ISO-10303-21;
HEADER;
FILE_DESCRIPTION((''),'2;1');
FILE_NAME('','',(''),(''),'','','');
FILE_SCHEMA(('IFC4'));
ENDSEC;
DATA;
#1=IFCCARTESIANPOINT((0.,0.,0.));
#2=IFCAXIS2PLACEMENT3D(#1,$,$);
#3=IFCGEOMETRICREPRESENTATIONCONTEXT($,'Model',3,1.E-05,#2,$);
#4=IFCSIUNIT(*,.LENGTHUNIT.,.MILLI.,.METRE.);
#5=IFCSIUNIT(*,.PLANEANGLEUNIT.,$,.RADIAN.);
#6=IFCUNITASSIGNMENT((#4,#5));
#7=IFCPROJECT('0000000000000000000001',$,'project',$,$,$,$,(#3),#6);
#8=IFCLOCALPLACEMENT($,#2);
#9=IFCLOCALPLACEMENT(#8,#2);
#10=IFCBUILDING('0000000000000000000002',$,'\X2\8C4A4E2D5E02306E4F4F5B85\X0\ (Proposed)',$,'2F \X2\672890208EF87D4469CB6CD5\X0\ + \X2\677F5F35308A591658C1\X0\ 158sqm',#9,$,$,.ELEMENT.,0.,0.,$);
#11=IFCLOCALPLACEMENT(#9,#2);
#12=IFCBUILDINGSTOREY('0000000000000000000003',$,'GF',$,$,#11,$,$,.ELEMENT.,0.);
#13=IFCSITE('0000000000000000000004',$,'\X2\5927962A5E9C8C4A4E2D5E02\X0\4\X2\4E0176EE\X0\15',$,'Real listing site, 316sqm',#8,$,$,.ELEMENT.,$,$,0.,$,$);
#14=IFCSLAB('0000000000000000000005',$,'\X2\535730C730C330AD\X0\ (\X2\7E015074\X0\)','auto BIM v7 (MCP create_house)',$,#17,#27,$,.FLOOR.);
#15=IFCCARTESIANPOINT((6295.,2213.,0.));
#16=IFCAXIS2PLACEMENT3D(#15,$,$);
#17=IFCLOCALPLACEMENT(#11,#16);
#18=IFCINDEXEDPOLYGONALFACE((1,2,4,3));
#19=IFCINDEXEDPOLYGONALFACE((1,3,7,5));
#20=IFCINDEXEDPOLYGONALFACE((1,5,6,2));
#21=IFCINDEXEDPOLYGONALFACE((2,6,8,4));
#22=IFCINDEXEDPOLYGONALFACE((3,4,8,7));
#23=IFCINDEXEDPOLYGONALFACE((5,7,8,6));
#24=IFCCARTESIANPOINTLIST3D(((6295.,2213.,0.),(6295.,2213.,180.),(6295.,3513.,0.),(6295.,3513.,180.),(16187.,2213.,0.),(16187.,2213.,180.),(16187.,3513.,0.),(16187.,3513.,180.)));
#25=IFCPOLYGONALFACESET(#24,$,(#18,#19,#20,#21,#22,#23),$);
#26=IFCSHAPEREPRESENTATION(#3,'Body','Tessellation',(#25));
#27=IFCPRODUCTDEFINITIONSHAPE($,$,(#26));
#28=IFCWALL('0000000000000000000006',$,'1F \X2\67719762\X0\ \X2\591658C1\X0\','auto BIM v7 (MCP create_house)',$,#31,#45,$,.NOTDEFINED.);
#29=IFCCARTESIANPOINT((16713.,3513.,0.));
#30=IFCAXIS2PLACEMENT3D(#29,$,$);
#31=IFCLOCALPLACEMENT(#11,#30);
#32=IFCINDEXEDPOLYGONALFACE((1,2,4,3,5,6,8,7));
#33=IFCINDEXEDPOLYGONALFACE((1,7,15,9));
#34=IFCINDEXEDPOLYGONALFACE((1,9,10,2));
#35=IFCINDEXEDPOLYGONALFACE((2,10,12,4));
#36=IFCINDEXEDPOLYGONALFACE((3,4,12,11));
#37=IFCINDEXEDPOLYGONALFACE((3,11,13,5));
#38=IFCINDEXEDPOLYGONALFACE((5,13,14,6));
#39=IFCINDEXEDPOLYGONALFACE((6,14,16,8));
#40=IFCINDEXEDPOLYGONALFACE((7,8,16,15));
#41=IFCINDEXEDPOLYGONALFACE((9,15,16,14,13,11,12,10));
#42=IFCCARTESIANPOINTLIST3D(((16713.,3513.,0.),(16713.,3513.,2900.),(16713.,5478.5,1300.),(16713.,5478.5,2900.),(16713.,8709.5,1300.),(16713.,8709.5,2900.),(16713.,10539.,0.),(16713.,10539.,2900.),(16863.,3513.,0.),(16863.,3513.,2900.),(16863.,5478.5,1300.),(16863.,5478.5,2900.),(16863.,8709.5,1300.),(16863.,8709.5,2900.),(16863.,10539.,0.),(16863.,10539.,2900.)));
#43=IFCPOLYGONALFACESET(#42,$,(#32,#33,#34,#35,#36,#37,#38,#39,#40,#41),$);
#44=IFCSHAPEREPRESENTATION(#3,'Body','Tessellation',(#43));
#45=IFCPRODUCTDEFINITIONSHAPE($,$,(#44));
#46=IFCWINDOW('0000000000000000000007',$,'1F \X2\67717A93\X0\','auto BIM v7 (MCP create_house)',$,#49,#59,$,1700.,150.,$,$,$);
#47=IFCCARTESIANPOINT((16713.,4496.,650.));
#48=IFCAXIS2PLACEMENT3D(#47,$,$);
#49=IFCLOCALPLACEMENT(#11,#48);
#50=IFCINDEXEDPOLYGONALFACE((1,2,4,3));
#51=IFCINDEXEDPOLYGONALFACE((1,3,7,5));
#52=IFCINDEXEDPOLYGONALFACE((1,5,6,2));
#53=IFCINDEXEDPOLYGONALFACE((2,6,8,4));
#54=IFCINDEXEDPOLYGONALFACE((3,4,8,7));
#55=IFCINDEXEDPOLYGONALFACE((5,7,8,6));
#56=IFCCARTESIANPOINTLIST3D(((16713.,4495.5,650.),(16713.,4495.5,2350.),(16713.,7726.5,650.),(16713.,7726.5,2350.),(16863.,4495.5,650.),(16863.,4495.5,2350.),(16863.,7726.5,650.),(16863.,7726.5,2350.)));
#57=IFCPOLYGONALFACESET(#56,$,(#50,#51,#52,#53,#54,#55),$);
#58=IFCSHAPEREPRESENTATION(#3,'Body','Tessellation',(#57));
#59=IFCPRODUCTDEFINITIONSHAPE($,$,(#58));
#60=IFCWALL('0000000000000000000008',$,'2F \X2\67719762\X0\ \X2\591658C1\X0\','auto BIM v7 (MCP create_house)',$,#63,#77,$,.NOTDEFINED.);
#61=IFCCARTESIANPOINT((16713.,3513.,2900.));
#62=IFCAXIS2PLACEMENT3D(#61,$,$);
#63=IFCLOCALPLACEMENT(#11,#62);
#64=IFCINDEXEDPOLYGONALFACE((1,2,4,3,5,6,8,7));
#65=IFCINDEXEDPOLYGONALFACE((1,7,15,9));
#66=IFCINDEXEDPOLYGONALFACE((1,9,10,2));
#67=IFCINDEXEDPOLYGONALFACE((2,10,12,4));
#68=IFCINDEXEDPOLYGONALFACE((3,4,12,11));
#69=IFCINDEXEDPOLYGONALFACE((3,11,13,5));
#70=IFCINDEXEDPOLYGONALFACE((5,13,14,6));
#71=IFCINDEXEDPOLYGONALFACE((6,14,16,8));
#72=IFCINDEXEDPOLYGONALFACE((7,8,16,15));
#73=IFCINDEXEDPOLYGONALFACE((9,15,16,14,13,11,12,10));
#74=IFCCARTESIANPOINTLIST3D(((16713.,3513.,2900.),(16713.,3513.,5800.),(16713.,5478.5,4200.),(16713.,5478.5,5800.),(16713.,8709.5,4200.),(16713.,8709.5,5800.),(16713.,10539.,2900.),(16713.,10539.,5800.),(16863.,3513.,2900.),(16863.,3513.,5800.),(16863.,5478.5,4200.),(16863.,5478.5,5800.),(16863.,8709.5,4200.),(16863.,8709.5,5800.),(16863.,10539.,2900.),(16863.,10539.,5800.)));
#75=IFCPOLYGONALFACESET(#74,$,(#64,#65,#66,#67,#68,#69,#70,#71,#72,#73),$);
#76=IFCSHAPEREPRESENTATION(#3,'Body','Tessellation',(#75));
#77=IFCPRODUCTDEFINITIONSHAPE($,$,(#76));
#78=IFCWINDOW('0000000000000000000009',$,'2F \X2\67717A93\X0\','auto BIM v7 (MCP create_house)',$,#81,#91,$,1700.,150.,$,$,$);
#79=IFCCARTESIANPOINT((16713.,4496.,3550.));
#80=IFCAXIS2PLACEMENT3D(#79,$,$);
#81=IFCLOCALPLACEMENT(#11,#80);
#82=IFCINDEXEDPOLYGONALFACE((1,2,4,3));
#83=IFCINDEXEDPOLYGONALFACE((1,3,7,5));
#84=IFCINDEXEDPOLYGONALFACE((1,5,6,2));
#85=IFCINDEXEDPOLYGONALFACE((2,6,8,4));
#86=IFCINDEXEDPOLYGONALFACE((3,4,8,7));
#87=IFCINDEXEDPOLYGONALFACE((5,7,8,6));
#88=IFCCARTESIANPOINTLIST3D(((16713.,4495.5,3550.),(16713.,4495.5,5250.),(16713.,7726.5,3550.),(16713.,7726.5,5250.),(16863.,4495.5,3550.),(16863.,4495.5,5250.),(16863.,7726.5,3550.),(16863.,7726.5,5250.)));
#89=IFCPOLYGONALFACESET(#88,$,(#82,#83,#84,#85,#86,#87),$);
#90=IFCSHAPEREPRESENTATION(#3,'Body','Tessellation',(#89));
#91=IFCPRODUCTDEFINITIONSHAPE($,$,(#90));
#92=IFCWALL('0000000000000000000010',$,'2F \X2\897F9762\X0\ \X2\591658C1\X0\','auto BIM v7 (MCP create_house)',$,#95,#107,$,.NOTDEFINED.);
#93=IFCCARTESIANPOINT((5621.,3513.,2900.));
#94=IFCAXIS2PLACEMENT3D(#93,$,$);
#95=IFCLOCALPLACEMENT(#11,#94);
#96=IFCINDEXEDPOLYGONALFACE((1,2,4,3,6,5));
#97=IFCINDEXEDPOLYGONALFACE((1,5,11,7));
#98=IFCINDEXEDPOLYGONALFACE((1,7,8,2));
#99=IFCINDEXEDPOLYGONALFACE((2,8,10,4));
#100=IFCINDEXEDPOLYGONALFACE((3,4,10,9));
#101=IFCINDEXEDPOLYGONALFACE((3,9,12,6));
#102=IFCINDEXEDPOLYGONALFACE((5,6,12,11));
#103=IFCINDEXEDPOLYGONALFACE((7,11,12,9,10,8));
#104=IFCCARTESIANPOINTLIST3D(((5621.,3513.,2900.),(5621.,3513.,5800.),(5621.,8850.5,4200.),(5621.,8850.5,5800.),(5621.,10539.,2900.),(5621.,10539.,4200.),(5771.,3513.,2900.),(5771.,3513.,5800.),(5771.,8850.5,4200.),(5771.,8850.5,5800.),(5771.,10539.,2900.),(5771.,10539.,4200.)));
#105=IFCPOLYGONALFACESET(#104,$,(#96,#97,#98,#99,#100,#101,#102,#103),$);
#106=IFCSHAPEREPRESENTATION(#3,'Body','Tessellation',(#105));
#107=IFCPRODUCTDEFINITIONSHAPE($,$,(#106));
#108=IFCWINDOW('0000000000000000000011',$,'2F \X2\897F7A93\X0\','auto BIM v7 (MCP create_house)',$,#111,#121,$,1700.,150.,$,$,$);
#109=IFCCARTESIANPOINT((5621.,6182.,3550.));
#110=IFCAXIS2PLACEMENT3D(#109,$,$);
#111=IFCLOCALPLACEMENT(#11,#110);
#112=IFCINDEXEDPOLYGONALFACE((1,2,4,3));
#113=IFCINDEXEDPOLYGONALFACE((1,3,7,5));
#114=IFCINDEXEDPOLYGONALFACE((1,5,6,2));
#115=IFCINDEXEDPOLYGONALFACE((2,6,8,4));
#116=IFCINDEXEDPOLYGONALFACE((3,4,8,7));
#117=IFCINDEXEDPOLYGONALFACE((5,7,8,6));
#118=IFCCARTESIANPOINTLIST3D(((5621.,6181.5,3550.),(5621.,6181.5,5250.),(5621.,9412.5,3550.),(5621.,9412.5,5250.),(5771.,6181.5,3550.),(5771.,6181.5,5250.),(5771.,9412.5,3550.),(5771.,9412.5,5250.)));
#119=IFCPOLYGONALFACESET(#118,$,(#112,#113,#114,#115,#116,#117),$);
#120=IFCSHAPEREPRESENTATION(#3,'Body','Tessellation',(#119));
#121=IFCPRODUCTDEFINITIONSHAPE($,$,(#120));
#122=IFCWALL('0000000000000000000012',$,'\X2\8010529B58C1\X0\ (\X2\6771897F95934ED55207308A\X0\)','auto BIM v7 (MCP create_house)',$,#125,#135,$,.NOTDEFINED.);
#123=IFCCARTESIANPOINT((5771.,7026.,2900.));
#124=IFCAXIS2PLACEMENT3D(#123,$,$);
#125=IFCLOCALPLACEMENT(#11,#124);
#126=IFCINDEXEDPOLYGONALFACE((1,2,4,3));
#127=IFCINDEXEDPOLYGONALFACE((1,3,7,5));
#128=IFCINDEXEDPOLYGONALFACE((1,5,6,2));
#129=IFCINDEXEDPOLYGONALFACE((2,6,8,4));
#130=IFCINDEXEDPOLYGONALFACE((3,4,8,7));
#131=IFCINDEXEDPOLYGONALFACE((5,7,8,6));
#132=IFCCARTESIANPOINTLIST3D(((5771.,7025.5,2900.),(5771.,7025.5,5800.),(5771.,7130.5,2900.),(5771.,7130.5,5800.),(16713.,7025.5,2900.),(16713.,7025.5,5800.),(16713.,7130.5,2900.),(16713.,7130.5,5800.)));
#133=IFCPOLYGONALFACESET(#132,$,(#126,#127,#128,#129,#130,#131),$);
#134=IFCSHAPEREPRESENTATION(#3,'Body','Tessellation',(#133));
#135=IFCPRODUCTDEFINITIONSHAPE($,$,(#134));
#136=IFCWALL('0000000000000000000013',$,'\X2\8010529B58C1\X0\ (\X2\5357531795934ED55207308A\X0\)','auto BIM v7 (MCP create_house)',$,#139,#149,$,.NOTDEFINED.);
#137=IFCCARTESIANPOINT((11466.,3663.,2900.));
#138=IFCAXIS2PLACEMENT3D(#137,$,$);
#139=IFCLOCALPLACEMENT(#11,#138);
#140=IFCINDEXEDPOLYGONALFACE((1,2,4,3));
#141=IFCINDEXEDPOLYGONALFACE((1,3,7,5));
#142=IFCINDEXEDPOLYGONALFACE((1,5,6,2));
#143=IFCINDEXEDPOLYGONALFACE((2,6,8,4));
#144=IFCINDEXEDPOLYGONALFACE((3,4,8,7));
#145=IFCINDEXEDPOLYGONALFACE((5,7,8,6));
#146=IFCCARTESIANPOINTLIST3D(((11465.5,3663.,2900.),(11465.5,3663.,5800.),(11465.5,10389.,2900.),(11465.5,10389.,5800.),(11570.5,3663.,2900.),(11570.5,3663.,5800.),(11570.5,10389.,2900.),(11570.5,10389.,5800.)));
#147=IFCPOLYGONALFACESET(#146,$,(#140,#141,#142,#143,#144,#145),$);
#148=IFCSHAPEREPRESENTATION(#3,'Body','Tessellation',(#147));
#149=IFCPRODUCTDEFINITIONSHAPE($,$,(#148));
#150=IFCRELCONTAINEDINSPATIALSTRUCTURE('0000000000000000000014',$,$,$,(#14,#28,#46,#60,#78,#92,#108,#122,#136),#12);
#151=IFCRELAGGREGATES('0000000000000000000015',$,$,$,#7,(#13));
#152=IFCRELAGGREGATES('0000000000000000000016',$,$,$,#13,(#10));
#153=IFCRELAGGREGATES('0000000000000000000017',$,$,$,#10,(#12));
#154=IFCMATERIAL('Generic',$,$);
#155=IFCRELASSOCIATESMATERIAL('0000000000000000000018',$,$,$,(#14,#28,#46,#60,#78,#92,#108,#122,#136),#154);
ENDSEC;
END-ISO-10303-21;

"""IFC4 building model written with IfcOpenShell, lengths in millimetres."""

from ifc_helpers import new_model, si_unit, frame, frame_2d, origin, place, context, project, spatial, rectangle, extrude, material, element, fill, save


model = new_model("IFC4")

# Units and contexts
model_context = context("Model", 3, precision=1e-05, world=origin())
ifc_project = project(units=[si_unit("LENGTHUNIT", "METRE", prefix="MILLI"), si_unit("PLANEANGLEUNIT", "RADIAN")], contexts=[model_context])

# Site, building, storey
site_placement = place(None, origin())
site = spatial("IfcSite", under=ifc_project, at=site_placement, Name="大阪府豊中市4丁目15", ObjectType="Real listing site, 316sqm", CompositionType="ELEMENT", RefElevation=0.0)
building_placement = place(site_placement, origin())
building = spatial("IfcBuilding", under=site, at=building_placement, Name="豊中市の住宅 (Proposed)", ObjectType="2F 木造軸組構法 + 板張り外壁 158sqm", CompositionType="ELEMENT", ElevationOfRefHeight=0.0, ElevationOfTerrain=0.0)
storey_placement = place(building_placement, origin())
storey = spatial("IfcBuildingStorey", under=building, at=storey_placement, Name="GF", CompositionType="ELEMENT", Elevation=0.0)

# Slab
ifc_material = material(Name="Generic")
slab_placement = place(storey_placement, frame((6295.0, 2213.0, 0.0)))
element("IfcSlab", 1, at=slab_placement, inside=storey, material=ifc_material, Name="南デッキ (縁側)", Description="auto BIM v7 (MCP create_house)", PredefinedType="FLOOR", context=model_context, shape_type="SweptSolid", body=[
    extrude(rectangle(XDim=9892.0, YDim=1300.0, at=frame_2d((4946.0, 650.0))), frame((6295.0, 2213.0, 0.0)), (0.0, 0.0, 1.0), 180.0),
])

# Wall, opening, window
wall_1_placement = place(storey_placement, frame((16713.0, 3513.0, 0.0)))
wall_1 = element("IfcWall", 2, at=wall_1_placement, inside=storey, material=ifc_material, Name="1F 東面 外壁", Description="auto BIM v7 (MCP create_house)", PredefinedType="NOTDEFINED", context=model_context, shape_type="SweptSolid", body=[
    extrude(rectangle(XDim=150.0, YDim=7026.0, at=frame_2d((75.0, 3513.0))), frame((16713.0, 3513.0, 0.0)), (0.0, 0.0, 1.0), 2900.0),
])
opening_1_placement = place(storey_placement, frame((16713.0, 4496.0, 650.0)))
opening_1 = element("IfcOpeningElement", 3, at=opening_1_placement, cuts=wall_1, PredefinedType="NOTDEFINED", context=model_context, shape_type="SweptSolid", body=[
    extrude(rectangle(XDim=150.0, YDim=3231.0, at=frame_2d((75.0, 1615.0))), frame((16713.0, 4496.0, 650.0)), (0.0, 0.0, 1.0), 1700.0),
])
window_1_placement = place(storey_placement, frame((16713.0, 4496.0, 650.0)))
window_1 = element("IfcWindow", 4, at=window_1_placement, inside=storey, material=ifc_material, Name="1F 東窓", Description="auto BIM v7 (MCP create_house)", OverallHeight=1700.0, OverallWidth=150.0, context=model_context, shape_type="SweptSolid", body=[
    extrude(rectangle(XDim=150.0, YDim=3231.0, at=frame_2d((75.0, 1615.0))), frame((16713.0, 4496.0, 650.0)), (0.0, 0.0, 1.0), 1700.0),
])
fill(opening_1, window_1)

# Walls, openings, windows
wall_2_placement = place(storey_placement, frame((16713.0, 3513.0, 2900.0)))
wall_2 = element("IfcWall", 5, at=wall_2_placement, inside=storey, material=ifc_material, Name="2F 東面 外壁", Description="auto BIM v7 (MCP create_house)", PredefinedType="NOTDEFINED", context=model_context, shape_type="SweptSolid", body=[
    extrude(rectangle(XDim=150.0, YDim=7026.0, at=frame_2d((75.0, 3513.0))), frame((16713.0, 3513.0, 2900.0)), (0.0, 0.0, 1.0), 2900.0),
])
opening_2_placement = place(storey_placement, frame((16713.0, 4496.0, 3550.0)))
opening_2 = element("IfcOpeningElement", 6, at=opening_2_placement, cuts=wall_2, PredefinedType="NOTDEFINED", context=model_context, shape_type="SweptSolid", body=[
    extrude(rectangle(XDim=150.0, YDim=3231.0, at=frame_2d((75.0, 1615.0))), frame((16713.0, 4496.0, 3550.0)), (0.0, 0.0, 1.0), 1700.0),
])
window_2_placement = place(storey_placement, frame((16713.0, 4496.0, 3550.0)))
window_2 = element("IfcWindow", 7, at=window_2_placement, inside=storey, material=ifc_material, Name="2F 東窓", Description="auto BIM v7 (MCP create_house)", OverallHeight=1700.0, OverallWidth=150.0, context=model_context, shape_type="SweptSolid", body=[
    extrude(rectangle(XDim=150.0, YDim=3231.0, at=frame_2d((75.0, 1615.0))), frame((16713.0, 4496.0, 3550.0)), (0.0, 0.0, 1.0), 1700.0),
])
fill(opening_2, window_2)
wall_3_placement = place(storey_placement, frame((5621.0, 3513.0, 2900.0)))
wall_3 = element("IfcWall", 8, at=wall_3_placement, inside=storey, material=ifc_material, Name="2F 西面 外壁", Description="auto BIM v7 (MCP create_house)", PredefinedType="NOTDEFINED", context=model_context, shape_type="SweptSolid", body=[
    extrude(rectangle(XDim=150.0, YDim=7026.0, at=frame_2d((75.0, 3513.0))), frame((5621.0, 3513.0, 2900.0)), (0.0, 0.0, 1.0), 2900.0),
])
opening_3_placement = place(storey_placement, frame((5621.0, 6182.0, 3550.0)))
opening_3 = element("IfcOpeningElement", 9, at=opening_3_placement, cuts=wall_3, PredefinedType="NOTDEFINED", context=model_context, shape_type="SweptSolid", body=[
    extrude(rectangle(XDim=150.0, YDim=3231.0, at=frame_2d((75.0, 1615.0))), frame((5621.0, 6182.0, 3550.0)), (0.0, 0.0, 1.0), 1700.0),
])
window_3_placement = place(storey_placement, frame((5621.0, 6182.0, 3550.0)))
window_3 = element("IfcWindow", 10, at=window_3_placement, inside=storey, material=ifc_material, Name="2F 西窓", Description="auto BIM v7 (MCP create_house)", OverallHeight=1700.0, OverallWidth=150.0, context=model_context, shape_type="SweptSolid", body=[
    extrude(rectangle(XDim=150.0, YDim=3231.0, at=frame_2d((75.0, 1615.0))), frame((5621.0, 6182.0, 3550.0)), (0.0, 0.0, 1.0), 1700.0),
])
fill(opening_3, window_3)

# Walls
wall_4_placement = place(storey_placement, frame((5771.0, 7026.0, 2900.0)))
element("IfcWall", 11, at=wall_4_placement, inside=storey, material=ifc_material, Name="耐力壁 (東西間仕切り)", Description="auto BIM v7 (MCP create_house)", PredefinedType="NOTDEFINED", context=model_context, shape_type="SweptSolid", body=[
    extrude(rectangle(XDim=10942.0, YDim=105.0, at=frame_2d((5471.0, 52.0))), frame((5771.0, 7026.0, 2900.0)), (0.0, 0.0, 1.0), 2900.0),
])
wall_5_placement = place(storey_placement, frame((11466.0, 3663.0, 2900.0)))
element("IfcWall", 12, at=wall_5_placement, inside=storey, material=ifc_material, Name="耐力壁 (南北間仕切り)", Description="auto BIM v7 (MCP create_house)", PredefinedType="NOTDEFINED", context=model_context, shape_type="SweptSolid", body=[
    extrude(rectangle(XDim=105.0, YDim=6726.0, at=frame_2d((52.0, 3363.0))), frame((11466.0, 3663.0, 2900.0)), (0.0, 0.0, 1.0), 2900.0),
])

save(model, "model.ifc")
